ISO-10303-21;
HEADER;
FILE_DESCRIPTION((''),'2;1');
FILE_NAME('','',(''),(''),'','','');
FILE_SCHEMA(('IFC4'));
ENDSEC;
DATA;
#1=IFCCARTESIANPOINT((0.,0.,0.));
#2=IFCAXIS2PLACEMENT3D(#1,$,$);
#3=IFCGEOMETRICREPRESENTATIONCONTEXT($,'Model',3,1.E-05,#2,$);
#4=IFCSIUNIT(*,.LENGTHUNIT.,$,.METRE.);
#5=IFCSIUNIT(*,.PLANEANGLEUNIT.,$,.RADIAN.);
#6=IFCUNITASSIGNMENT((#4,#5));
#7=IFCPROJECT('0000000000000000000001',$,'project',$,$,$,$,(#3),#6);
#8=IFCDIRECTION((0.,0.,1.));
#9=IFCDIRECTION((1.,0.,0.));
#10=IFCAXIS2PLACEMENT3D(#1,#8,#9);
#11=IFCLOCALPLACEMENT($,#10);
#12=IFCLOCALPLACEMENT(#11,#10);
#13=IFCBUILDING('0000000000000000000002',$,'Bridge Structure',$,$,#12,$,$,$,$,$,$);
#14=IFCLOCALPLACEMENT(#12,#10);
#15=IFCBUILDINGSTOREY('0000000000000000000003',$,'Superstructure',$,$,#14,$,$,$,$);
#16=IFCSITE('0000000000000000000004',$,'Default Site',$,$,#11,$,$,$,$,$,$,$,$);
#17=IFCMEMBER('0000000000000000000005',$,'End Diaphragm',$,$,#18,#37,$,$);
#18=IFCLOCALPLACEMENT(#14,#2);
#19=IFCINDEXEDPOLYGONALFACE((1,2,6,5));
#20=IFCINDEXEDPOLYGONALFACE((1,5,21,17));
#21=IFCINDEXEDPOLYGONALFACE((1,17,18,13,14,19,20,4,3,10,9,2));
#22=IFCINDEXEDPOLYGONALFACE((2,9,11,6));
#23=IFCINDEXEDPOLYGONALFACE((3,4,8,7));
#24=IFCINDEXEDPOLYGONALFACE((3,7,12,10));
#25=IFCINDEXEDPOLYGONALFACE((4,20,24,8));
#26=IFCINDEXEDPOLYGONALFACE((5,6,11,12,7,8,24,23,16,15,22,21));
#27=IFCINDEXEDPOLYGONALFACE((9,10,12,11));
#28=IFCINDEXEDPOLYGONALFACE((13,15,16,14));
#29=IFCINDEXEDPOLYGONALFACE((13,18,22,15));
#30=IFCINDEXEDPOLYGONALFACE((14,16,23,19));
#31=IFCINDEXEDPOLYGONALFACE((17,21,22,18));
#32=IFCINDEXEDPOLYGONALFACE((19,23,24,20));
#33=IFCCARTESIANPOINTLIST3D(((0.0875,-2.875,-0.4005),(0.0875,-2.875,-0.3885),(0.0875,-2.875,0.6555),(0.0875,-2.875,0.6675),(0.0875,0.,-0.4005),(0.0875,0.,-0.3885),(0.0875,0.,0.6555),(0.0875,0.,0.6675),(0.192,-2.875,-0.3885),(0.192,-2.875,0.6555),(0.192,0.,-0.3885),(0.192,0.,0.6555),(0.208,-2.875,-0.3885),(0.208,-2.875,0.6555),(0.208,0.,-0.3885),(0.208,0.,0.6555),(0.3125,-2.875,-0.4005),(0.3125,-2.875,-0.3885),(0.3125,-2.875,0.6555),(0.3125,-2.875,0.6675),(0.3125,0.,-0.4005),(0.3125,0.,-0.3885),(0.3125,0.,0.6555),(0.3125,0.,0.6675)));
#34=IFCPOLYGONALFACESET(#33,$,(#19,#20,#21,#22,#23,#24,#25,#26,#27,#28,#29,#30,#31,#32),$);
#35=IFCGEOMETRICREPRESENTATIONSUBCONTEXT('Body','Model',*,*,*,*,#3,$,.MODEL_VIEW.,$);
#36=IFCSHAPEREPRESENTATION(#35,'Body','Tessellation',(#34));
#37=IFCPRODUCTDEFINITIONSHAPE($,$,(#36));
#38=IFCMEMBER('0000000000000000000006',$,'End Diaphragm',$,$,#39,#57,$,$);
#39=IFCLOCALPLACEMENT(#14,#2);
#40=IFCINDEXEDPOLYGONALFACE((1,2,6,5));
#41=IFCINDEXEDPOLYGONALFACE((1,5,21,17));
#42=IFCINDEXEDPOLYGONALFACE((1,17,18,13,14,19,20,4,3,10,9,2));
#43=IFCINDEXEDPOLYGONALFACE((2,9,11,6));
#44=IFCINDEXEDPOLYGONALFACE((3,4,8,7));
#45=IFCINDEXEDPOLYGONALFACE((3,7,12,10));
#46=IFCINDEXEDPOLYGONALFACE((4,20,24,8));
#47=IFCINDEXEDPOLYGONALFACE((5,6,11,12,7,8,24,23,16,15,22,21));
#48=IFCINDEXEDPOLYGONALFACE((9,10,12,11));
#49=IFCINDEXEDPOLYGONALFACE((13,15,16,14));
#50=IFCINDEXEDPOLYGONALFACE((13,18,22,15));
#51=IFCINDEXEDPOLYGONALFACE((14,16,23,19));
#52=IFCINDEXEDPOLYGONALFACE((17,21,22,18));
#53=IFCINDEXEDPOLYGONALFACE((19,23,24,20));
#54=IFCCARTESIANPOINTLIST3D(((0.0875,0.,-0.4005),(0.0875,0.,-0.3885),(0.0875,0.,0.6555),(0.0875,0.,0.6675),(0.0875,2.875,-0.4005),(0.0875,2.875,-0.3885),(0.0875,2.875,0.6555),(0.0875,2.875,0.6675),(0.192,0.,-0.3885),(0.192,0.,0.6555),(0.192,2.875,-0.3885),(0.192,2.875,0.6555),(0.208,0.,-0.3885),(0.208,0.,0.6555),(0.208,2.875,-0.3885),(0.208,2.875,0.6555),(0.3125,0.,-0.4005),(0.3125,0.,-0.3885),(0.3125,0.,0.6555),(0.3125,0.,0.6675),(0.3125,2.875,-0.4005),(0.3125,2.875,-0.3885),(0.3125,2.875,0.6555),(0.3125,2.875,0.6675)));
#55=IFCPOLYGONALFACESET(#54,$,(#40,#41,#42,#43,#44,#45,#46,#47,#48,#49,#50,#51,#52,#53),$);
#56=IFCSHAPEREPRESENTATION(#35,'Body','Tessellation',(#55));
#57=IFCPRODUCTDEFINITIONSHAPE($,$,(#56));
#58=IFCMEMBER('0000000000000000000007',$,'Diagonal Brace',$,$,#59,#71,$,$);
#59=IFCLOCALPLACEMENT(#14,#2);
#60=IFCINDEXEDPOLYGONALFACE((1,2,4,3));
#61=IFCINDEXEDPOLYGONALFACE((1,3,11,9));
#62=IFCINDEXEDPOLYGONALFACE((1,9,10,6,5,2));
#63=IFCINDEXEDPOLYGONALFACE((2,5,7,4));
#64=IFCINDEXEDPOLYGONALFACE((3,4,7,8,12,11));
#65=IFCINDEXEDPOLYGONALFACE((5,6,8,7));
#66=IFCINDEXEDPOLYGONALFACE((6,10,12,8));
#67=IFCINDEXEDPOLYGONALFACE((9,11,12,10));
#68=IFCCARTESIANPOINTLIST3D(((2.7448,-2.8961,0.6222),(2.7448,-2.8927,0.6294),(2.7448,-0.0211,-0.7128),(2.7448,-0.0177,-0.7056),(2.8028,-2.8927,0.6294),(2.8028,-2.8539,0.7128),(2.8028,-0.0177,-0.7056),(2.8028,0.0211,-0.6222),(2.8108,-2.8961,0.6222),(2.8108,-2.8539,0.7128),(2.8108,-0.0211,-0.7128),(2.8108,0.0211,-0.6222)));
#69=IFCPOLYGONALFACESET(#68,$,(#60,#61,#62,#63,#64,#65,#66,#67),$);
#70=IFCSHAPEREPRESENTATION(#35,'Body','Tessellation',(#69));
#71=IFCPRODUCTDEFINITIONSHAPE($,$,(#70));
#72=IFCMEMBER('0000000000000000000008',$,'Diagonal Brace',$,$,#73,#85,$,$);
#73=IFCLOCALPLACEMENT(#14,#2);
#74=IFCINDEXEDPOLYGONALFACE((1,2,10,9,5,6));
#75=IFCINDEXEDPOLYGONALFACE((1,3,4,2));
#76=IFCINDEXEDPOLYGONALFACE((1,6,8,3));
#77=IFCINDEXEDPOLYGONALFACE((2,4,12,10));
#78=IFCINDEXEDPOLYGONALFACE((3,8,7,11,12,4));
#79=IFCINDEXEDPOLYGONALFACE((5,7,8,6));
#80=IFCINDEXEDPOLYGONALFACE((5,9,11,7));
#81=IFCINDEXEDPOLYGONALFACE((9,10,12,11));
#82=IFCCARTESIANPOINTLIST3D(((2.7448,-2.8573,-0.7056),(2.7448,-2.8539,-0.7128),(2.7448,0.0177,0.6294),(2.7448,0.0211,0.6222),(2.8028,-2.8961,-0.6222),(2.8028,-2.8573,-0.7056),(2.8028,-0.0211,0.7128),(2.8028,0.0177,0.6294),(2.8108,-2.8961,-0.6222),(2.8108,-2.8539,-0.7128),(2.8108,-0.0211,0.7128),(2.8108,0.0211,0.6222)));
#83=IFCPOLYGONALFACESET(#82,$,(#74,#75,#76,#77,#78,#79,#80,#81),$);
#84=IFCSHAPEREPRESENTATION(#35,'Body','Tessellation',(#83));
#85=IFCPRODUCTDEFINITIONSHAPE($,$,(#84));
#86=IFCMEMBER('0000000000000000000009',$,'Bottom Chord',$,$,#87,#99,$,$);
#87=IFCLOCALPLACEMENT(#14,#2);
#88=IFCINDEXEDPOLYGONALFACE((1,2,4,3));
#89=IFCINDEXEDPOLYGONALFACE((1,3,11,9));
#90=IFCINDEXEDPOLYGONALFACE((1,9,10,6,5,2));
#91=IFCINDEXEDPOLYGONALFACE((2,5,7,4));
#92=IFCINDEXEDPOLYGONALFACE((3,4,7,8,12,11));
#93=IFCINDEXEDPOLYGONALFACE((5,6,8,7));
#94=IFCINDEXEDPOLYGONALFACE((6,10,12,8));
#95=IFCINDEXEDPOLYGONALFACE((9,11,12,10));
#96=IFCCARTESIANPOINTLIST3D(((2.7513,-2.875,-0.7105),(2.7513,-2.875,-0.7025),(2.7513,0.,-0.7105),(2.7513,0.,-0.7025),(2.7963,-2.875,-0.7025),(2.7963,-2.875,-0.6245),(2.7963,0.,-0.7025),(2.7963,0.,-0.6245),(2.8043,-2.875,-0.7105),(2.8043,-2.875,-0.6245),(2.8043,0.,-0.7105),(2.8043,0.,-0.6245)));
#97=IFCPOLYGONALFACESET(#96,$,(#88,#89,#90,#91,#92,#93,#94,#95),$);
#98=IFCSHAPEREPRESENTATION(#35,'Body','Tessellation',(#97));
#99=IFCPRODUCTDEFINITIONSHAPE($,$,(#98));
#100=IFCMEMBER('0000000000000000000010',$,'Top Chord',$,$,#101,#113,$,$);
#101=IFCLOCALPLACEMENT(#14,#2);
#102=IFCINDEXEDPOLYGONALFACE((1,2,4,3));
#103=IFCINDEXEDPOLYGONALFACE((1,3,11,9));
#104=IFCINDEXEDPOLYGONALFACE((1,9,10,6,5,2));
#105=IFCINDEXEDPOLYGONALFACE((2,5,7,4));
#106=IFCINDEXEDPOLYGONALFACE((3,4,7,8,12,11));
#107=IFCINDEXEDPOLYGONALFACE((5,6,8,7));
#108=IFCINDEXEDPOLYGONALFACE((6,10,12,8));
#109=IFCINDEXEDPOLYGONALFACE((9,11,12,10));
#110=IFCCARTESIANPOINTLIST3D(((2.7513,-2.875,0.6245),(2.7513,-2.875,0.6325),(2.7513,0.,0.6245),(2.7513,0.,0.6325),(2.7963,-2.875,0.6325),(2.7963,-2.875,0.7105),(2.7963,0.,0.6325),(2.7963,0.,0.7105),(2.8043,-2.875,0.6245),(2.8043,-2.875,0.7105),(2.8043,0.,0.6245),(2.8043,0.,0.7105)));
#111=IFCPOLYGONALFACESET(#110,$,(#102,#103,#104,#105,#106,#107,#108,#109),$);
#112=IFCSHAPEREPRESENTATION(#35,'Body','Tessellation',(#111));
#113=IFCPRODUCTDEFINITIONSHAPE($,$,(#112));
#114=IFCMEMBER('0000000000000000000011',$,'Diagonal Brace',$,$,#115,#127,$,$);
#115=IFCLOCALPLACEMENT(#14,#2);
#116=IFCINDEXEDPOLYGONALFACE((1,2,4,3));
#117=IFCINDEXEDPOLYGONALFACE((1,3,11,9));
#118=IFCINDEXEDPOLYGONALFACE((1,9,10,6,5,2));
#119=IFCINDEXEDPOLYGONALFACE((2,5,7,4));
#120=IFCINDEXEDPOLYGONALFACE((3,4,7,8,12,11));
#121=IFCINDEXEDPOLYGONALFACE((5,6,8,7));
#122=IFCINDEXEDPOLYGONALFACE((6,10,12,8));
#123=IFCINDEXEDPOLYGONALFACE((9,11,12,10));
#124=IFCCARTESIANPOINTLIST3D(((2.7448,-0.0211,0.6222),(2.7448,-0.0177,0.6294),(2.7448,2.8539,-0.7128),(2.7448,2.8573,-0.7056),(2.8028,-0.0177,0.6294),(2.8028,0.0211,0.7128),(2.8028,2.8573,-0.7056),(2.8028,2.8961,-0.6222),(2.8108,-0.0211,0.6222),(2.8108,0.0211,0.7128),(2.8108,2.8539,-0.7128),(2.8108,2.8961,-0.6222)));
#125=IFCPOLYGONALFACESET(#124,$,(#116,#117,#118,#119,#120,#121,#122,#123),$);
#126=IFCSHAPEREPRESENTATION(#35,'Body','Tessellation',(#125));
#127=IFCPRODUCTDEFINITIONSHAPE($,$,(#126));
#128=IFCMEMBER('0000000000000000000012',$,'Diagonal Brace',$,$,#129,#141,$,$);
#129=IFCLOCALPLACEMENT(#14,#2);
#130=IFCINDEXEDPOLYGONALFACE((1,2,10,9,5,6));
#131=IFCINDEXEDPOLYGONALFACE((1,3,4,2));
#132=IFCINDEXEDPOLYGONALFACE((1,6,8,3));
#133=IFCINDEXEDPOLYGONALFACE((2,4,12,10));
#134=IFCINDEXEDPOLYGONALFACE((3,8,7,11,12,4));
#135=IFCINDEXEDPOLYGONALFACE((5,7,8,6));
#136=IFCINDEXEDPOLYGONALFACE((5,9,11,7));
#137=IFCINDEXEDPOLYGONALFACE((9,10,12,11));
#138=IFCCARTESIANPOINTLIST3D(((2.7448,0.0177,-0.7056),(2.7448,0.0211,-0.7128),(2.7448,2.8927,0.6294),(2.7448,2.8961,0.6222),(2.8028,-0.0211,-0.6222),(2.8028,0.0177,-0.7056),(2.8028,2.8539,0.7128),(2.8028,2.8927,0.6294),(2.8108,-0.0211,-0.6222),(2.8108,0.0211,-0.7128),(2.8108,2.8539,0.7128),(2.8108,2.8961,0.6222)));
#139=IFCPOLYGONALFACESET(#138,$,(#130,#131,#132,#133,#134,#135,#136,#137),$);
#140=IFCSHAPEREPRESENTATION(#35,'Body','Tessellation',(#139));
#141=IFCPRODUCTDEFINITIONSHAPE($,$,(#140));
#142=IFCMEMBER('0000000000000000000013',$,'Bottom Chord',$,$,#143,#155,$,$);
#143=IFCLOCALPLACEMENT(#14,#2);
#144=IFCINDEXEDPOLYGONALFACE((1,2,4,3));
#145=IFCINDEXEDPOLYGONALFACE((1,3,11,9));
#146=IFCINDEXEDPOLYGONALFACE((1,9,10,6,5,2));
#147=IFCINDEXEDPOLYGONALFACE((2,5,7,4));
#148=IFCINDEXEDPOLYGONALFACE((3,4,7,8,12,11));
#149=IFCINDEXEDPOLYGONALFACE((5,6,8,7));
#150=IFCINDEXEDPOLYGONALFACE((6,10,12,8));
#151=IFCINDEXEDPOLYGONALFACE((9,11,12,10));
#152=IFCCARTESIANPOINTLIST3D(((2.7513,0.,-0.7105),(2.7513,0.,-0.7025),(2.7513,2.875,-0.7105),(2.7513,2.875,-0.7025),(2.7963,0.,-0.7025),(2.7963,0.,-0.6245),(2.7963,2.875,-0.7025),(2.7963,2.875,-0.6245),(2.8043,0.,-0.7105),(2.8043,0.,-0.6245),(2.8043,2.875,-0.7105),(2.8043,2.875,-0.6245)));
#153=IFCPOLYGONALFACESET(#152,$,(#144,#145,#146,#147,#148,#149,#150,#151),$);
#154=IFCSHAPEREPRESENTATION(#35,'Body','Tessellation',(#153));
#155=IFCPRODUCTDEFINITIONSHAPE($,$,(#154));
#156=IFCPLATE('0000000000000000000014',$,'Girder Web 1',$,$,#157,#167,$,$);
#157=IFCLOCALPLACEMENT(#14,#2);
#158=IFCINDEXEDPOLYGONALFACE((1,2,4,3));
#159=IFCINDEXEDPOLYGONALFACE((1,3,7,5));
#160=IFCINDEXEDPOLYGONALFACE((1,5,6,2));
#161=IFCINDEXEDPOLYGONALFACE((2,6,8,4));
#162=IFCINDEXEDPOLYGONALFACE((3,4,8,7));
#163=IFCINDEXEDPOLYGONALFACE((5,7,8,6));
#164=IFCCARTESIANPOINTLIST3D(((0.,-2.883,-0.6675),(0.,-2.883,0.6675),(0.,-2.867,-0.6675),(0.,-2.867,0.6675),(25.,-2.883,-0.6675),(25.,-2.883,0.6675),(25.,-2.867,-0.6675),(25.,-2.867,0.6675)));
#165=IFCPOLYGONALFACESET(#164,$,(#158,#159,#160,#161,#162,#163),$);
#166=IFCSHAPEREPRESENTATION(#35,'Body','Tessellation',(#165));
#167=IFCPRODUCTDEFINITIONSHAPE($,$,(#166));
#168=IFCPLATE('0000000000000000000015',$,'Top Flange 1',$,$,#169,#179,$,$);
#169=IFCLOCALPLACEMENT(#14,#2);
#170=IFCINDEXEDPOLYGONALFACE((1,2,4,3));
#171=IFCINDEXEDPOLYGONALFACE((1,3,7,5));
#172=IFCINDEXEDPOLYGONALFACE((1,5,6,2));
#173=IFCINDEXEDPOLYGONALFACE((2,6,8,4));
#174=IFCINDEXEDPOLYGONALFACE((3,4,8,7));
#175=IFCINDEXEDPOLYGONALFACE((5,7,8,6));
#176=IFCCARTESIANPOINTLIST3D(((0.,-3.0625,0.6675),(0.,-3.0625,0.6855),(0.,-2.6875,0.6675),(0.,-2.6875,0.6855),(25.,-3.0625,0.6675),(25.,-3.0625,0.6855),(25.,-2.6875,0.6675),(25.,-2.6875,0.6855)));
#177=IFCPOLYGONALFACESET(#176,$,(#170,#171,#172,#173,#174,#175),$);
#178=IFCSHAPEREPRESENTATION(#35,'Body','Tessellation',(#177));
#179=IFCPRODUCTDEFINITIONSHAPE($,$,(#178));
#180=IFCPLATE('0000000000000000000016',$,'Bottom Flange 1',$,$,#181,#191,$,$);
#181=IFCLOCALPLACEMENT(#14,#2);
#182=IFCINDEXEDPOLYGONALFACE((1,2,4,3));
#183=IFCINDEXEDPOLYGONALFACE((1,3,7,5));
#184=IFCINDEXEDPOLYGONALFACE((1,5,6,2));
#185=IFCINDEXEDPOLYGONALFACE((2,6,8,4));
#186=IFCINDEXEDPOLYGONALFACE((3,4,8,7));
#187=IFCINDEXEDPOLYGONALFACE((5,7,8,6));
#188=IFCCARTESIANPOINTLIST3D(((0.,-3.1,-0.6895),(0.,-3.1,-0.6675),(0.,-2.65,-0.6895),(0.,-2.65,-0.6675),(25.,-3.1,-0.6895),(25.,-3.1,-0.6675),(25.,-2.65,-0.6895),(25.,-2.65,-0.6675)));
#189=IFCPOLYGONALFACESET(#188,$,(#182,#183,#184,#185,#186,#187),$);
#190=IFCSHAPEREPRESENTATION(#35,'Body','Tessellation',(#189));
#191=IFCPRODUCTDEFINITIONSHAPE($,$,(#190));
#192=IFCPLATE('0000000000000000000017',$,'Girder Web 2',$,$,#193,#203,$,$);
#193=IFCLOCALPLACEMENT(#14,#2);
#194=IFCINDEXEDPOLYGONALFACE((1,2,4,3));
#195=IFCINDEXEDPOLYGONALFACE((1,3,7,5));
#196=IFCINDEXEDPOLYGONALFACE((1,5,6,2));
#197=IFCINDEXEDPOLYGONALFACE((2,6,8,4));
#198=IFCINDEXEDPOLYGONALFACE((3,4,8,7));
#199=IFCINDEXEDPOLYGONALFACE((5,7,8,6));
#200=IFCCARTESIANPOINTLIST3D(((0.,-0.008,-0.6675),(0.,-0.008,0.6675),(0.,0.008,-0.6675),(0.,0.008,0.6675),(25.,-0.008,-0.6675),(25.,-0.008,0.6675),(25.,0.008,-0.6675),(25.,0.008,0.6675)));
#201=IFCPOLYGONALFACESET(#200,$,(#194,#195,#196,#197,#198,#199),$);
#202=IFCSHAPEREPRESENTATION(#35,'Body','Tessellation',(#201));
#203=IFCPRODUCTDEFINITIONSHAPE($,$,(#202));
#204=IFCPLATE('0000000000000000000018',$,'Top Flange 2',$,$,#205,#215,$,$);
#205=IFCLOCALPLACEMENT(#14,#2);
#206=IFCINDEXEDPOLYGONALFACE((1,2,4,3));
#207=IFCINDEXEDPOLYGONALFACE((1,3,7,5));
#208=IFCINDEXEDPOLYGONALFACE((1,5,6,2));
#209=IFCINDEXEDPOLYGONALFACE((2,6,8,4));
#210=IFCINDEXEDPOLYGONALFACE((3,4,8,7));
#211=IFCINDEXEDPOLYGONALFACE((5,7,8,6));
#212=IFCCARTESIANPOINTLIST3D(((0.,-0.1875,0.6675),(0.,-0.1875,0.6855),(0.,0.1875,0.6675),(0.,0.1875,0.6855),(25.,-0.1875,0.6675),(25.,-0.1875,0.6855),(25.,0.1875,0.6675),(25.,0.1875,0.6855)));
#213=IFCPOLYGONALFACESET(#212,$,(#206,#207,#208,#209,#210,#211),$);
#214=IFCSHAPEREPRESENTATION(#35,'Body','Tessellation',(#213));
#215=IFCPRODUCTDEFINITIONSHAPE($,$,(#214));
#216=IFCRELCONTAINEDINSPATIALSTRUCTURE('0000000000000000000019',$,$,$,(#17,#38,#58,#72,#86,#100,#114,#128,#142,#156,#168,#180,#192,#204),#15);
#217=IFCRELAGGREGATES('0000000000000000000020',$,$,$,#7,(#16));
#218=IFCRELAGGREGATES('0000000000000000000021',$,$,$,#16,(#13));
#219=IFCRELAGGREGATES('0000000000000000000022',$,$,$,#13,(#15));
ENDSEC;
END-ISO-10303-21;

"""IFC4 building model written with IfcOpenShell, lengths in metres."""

from ifc_helpers import new_model, si_unit, frame, origin, origin_with_axes, origin_2d_with_axis, place, context, subcontext, project, spatial, rectangle, i_section, l_section, extrude, element, save


model = new_model("IFC4")

# Units and contexts
model_context = context("Model", 3, precision=1e-05, world=origin())
body_context = subcontext(model_context, "Body", "Model", "MODEL_VIEW")
ifc_project = project(units=[si_unit("LENGTHUNIT", "METRE"), si_unit("PLANEANGLEUNIT", "RADIAN")], contexts=[model_context])

# Site, building, storey
site_placement = place(None, origin_with_axes())
site = spatial("IfcSite", under=ifc_project, at=site_placement, Name="Default Site")
building_placement = place(site_placement, origin_with_axes())
building = spatial("IfcBuilding", under=site, at=building_placement, Name="Bridge Structure")
storey_placement = place(building_placement, origin_with_axes())
storey = spatial("IfcBuildingStorey", under=building, at=storey_placement, Name="Superstructure")

# Members
for number, where, z_axis, x_axis, name in (
    (1, (0.2, -2.875, 0.1335), (0.0, 1.0, 0.0), (-1.0, 0.0, 0.0), "End Diaphragm"),
    (2, (0.2, 0.0, 0.1335), (0.0, 1.0, 0.0), (-1.0, 0.0, 0.0), "End Diaphragm"),
):
    element("IfcMember", number, at=place(storey_placement, frame(where, z_axis=z_axis, x_axis=x_axis)), inside=storey, Name=name, context=body_context, shape_type="SweptSolid", body=[
        extrude(i_section(OverallWidth=0.225, OverallDepth=1.068, WebThickness=0.016, FlangeThickness=0.012, at=origin_2d_with_axis()), origin_with_axes(), (0.0, 0.0, 1.0), 2.875),
    ])
for number, where, z_axis, x_axis, name in (
    (3, (2.7778, -2.875, 0.6675), (0.0, 0.906987, -0.421158), (-1.0, 0.0, 0.0), "Diagonal Brace"),
    (4, (2.7778, -2.875, -0.6675), (0.0, 0.906987, 0.421158), (-1.0, 0.0, 0.0), "Diagonal Brace"),
):
    element("IfcMember", number, at=place(storey_placement, frame(where, z_axis=z_axis, x_axis=x_axis)), inside=storey, Name=name, context=body_context, shape_type="SweptSolid", body=[
        extrude(l_section(Depth=0.1, Width=0.066, Thickness=0.008, at=origin_2d_with_axis()), origin_with_axes(), (0.0, 0.0, 1.0), 3.1698),
    ])
for number, where, z_axis, x_axis, name in (
    (5, (2.7778, -2.875, -0.6675), (0.0, 1.0, 0.0), (-1.0, 0.0, 0.0), "Bottom Chord"),
    (6, (2.7778, -2.875, 0.6675), (0.0, 1.0, 0.0), (-1.0, 0.0, 0.0), "Top Chord"),
):
    element("IfcMember", number, at=place(storey_placement, frame(where, z_axis=z_axis, x_axis=x_axis)), inside=storey, Name=name, context=body_context, shape_type="SweptSolid", body=[
        extrude(l_section(Depth=0.086, Width=0.053, Thickness=0.008, at=origin_2d_with_axis()), origin_with_axes(), (0.0, 0.0, 1.0), 2.875),
    ])
for number, where, z_axis, x_axis, name in (
    (7, (2.7778, 0.0, 0.6675), (0.0, 0.906987, -0.421158), (-1.0, 0.0, 0.0), "Diagonal Brace"),
    (8, (2.7778, 0.0, -0.6675), (0.0, 0.906987, 0.421158), (-1.0, 0.0, 0.0), "Diagonal Brace"),
):
    element("IfcMember", number, at=place(storey_placement, frame(where, z_axis=z_axis, x_axis=x_axis)), inside=storey, Name=name, context=body_context, shape_type="SweptSolid", body=[
        extrude(l_section(Depth=0.1, Width=0.066, Thickness=0.008, at=origin_2d_with_axis()), origin_with_axes(), (0.0, 0.0, 1.0), 3.1698),
    ])
member_placement = place(storey_placement, frame((2.7778, 0.0, -0.6675), z_axis=(0.0, 1.0, 0.0), x_axis=(-1.0, 0.0, 0.0)))
element("IfcMember", 9, at=member_placement, inside=storey, Name="Bottom Chord", context=body_context, shape_type="SweptSolid", body=[
    extrude(l_section(Depth=0.086, Width=0.053, Thickness=0.008, at=origin_2d_with_axis()), origin_with_axes(), (0.0, 0.0, 1.0), 2.875),
])

# Plates
plate_1_placement = place(storey_placement, frame((0.0, -2.875, 0.0), z_axis=(1.0, 0.0, 0.0), x_axis=(0.0, 1.0, 0.0)))
element("IfcPlate", 10, at=plate_1_placement, inside=storey, Name="Girder Web 1", context=body_context, shape_type="SweptSolid", body=[
    extrude(rectangle(XDim=0.016, YDim=1.335, at=origin_2d_with_axis()), origin_with_axes(), (0.0, 0.0, 1.0), 25.0),
])
plate_2_placement = place(storey_placement, frame((0.0, -2.875, 0.6765), z_axis=(1.0, 0.0, 0.0), x_axis=(0.0, 1.0, 0.0)))
element("IfcPlate", 11, at=plate_2_placement, inside=storey, Name="Top Flange 1", context=body_context, shape_type="SweptSolid", body=[
    extrude(rectangle(XDim=0.375, YDim=0.018, at=origin_2d_with_axis()), origin_with_axes(), (0.0, 0.0, 1.0), 25.0),
])
plate_3_placement = place(storey_placement, frame((0.0, -2.875, -0.6785), z_axis=(1.0, 0.0, 0.0), x_axis=(0.0, 1.0, 0.0)))
element("IfcPlate", 12, at=plate_3_placement, inside=storey, Name="Bottom Flange 1", context=body_context, shape_type="SweptSolid", body=[
    extrude(rectangle(XDim=0.45, YDim=0.022, at=origin_2d_with_axis()), origin_with_axes(), (0.0, 0.0, 1.0), 25.0),
])
plate_4_placement = place(storey_placement, frame((0.0, 0.0, 0.0), z_axis=(1.0, 0.0, 0.0), x_axis=(0.0, 1.0, 0.0)))
element("IfcPlate", 13, at=plate_4_placement, inside=storey, Name="Girder Web 2", context=body_context, shape_type="SweptSolid", body=[
    extrude(rectangle(XDim=0.016, YDim=1.335, at=origin_2d_with_axis()), origin_with_axes(), (0.0, 0.0, 1.0), 25.0),
])
plate_5_placement = place(storey_placement, frame((0.0, 0.0, 0.6765), z_axis=(1.0, 0.0, 0.0), x_axis=(0.0, 1.0, 0.0)))
element("IfcPlate", 14, at=plate_5_placement, inside=storey, Name="Top Flange 2", context=body_context, shape_type="SweptSolid", body=[
    extrude(rectangle(XDim=0.375, YDim=0.018, at=origin_2d_with_axis()), origin_with_axes(), (0.0, 0.0, 1.0), 25.0),
])

save(model, "model.ifc")
